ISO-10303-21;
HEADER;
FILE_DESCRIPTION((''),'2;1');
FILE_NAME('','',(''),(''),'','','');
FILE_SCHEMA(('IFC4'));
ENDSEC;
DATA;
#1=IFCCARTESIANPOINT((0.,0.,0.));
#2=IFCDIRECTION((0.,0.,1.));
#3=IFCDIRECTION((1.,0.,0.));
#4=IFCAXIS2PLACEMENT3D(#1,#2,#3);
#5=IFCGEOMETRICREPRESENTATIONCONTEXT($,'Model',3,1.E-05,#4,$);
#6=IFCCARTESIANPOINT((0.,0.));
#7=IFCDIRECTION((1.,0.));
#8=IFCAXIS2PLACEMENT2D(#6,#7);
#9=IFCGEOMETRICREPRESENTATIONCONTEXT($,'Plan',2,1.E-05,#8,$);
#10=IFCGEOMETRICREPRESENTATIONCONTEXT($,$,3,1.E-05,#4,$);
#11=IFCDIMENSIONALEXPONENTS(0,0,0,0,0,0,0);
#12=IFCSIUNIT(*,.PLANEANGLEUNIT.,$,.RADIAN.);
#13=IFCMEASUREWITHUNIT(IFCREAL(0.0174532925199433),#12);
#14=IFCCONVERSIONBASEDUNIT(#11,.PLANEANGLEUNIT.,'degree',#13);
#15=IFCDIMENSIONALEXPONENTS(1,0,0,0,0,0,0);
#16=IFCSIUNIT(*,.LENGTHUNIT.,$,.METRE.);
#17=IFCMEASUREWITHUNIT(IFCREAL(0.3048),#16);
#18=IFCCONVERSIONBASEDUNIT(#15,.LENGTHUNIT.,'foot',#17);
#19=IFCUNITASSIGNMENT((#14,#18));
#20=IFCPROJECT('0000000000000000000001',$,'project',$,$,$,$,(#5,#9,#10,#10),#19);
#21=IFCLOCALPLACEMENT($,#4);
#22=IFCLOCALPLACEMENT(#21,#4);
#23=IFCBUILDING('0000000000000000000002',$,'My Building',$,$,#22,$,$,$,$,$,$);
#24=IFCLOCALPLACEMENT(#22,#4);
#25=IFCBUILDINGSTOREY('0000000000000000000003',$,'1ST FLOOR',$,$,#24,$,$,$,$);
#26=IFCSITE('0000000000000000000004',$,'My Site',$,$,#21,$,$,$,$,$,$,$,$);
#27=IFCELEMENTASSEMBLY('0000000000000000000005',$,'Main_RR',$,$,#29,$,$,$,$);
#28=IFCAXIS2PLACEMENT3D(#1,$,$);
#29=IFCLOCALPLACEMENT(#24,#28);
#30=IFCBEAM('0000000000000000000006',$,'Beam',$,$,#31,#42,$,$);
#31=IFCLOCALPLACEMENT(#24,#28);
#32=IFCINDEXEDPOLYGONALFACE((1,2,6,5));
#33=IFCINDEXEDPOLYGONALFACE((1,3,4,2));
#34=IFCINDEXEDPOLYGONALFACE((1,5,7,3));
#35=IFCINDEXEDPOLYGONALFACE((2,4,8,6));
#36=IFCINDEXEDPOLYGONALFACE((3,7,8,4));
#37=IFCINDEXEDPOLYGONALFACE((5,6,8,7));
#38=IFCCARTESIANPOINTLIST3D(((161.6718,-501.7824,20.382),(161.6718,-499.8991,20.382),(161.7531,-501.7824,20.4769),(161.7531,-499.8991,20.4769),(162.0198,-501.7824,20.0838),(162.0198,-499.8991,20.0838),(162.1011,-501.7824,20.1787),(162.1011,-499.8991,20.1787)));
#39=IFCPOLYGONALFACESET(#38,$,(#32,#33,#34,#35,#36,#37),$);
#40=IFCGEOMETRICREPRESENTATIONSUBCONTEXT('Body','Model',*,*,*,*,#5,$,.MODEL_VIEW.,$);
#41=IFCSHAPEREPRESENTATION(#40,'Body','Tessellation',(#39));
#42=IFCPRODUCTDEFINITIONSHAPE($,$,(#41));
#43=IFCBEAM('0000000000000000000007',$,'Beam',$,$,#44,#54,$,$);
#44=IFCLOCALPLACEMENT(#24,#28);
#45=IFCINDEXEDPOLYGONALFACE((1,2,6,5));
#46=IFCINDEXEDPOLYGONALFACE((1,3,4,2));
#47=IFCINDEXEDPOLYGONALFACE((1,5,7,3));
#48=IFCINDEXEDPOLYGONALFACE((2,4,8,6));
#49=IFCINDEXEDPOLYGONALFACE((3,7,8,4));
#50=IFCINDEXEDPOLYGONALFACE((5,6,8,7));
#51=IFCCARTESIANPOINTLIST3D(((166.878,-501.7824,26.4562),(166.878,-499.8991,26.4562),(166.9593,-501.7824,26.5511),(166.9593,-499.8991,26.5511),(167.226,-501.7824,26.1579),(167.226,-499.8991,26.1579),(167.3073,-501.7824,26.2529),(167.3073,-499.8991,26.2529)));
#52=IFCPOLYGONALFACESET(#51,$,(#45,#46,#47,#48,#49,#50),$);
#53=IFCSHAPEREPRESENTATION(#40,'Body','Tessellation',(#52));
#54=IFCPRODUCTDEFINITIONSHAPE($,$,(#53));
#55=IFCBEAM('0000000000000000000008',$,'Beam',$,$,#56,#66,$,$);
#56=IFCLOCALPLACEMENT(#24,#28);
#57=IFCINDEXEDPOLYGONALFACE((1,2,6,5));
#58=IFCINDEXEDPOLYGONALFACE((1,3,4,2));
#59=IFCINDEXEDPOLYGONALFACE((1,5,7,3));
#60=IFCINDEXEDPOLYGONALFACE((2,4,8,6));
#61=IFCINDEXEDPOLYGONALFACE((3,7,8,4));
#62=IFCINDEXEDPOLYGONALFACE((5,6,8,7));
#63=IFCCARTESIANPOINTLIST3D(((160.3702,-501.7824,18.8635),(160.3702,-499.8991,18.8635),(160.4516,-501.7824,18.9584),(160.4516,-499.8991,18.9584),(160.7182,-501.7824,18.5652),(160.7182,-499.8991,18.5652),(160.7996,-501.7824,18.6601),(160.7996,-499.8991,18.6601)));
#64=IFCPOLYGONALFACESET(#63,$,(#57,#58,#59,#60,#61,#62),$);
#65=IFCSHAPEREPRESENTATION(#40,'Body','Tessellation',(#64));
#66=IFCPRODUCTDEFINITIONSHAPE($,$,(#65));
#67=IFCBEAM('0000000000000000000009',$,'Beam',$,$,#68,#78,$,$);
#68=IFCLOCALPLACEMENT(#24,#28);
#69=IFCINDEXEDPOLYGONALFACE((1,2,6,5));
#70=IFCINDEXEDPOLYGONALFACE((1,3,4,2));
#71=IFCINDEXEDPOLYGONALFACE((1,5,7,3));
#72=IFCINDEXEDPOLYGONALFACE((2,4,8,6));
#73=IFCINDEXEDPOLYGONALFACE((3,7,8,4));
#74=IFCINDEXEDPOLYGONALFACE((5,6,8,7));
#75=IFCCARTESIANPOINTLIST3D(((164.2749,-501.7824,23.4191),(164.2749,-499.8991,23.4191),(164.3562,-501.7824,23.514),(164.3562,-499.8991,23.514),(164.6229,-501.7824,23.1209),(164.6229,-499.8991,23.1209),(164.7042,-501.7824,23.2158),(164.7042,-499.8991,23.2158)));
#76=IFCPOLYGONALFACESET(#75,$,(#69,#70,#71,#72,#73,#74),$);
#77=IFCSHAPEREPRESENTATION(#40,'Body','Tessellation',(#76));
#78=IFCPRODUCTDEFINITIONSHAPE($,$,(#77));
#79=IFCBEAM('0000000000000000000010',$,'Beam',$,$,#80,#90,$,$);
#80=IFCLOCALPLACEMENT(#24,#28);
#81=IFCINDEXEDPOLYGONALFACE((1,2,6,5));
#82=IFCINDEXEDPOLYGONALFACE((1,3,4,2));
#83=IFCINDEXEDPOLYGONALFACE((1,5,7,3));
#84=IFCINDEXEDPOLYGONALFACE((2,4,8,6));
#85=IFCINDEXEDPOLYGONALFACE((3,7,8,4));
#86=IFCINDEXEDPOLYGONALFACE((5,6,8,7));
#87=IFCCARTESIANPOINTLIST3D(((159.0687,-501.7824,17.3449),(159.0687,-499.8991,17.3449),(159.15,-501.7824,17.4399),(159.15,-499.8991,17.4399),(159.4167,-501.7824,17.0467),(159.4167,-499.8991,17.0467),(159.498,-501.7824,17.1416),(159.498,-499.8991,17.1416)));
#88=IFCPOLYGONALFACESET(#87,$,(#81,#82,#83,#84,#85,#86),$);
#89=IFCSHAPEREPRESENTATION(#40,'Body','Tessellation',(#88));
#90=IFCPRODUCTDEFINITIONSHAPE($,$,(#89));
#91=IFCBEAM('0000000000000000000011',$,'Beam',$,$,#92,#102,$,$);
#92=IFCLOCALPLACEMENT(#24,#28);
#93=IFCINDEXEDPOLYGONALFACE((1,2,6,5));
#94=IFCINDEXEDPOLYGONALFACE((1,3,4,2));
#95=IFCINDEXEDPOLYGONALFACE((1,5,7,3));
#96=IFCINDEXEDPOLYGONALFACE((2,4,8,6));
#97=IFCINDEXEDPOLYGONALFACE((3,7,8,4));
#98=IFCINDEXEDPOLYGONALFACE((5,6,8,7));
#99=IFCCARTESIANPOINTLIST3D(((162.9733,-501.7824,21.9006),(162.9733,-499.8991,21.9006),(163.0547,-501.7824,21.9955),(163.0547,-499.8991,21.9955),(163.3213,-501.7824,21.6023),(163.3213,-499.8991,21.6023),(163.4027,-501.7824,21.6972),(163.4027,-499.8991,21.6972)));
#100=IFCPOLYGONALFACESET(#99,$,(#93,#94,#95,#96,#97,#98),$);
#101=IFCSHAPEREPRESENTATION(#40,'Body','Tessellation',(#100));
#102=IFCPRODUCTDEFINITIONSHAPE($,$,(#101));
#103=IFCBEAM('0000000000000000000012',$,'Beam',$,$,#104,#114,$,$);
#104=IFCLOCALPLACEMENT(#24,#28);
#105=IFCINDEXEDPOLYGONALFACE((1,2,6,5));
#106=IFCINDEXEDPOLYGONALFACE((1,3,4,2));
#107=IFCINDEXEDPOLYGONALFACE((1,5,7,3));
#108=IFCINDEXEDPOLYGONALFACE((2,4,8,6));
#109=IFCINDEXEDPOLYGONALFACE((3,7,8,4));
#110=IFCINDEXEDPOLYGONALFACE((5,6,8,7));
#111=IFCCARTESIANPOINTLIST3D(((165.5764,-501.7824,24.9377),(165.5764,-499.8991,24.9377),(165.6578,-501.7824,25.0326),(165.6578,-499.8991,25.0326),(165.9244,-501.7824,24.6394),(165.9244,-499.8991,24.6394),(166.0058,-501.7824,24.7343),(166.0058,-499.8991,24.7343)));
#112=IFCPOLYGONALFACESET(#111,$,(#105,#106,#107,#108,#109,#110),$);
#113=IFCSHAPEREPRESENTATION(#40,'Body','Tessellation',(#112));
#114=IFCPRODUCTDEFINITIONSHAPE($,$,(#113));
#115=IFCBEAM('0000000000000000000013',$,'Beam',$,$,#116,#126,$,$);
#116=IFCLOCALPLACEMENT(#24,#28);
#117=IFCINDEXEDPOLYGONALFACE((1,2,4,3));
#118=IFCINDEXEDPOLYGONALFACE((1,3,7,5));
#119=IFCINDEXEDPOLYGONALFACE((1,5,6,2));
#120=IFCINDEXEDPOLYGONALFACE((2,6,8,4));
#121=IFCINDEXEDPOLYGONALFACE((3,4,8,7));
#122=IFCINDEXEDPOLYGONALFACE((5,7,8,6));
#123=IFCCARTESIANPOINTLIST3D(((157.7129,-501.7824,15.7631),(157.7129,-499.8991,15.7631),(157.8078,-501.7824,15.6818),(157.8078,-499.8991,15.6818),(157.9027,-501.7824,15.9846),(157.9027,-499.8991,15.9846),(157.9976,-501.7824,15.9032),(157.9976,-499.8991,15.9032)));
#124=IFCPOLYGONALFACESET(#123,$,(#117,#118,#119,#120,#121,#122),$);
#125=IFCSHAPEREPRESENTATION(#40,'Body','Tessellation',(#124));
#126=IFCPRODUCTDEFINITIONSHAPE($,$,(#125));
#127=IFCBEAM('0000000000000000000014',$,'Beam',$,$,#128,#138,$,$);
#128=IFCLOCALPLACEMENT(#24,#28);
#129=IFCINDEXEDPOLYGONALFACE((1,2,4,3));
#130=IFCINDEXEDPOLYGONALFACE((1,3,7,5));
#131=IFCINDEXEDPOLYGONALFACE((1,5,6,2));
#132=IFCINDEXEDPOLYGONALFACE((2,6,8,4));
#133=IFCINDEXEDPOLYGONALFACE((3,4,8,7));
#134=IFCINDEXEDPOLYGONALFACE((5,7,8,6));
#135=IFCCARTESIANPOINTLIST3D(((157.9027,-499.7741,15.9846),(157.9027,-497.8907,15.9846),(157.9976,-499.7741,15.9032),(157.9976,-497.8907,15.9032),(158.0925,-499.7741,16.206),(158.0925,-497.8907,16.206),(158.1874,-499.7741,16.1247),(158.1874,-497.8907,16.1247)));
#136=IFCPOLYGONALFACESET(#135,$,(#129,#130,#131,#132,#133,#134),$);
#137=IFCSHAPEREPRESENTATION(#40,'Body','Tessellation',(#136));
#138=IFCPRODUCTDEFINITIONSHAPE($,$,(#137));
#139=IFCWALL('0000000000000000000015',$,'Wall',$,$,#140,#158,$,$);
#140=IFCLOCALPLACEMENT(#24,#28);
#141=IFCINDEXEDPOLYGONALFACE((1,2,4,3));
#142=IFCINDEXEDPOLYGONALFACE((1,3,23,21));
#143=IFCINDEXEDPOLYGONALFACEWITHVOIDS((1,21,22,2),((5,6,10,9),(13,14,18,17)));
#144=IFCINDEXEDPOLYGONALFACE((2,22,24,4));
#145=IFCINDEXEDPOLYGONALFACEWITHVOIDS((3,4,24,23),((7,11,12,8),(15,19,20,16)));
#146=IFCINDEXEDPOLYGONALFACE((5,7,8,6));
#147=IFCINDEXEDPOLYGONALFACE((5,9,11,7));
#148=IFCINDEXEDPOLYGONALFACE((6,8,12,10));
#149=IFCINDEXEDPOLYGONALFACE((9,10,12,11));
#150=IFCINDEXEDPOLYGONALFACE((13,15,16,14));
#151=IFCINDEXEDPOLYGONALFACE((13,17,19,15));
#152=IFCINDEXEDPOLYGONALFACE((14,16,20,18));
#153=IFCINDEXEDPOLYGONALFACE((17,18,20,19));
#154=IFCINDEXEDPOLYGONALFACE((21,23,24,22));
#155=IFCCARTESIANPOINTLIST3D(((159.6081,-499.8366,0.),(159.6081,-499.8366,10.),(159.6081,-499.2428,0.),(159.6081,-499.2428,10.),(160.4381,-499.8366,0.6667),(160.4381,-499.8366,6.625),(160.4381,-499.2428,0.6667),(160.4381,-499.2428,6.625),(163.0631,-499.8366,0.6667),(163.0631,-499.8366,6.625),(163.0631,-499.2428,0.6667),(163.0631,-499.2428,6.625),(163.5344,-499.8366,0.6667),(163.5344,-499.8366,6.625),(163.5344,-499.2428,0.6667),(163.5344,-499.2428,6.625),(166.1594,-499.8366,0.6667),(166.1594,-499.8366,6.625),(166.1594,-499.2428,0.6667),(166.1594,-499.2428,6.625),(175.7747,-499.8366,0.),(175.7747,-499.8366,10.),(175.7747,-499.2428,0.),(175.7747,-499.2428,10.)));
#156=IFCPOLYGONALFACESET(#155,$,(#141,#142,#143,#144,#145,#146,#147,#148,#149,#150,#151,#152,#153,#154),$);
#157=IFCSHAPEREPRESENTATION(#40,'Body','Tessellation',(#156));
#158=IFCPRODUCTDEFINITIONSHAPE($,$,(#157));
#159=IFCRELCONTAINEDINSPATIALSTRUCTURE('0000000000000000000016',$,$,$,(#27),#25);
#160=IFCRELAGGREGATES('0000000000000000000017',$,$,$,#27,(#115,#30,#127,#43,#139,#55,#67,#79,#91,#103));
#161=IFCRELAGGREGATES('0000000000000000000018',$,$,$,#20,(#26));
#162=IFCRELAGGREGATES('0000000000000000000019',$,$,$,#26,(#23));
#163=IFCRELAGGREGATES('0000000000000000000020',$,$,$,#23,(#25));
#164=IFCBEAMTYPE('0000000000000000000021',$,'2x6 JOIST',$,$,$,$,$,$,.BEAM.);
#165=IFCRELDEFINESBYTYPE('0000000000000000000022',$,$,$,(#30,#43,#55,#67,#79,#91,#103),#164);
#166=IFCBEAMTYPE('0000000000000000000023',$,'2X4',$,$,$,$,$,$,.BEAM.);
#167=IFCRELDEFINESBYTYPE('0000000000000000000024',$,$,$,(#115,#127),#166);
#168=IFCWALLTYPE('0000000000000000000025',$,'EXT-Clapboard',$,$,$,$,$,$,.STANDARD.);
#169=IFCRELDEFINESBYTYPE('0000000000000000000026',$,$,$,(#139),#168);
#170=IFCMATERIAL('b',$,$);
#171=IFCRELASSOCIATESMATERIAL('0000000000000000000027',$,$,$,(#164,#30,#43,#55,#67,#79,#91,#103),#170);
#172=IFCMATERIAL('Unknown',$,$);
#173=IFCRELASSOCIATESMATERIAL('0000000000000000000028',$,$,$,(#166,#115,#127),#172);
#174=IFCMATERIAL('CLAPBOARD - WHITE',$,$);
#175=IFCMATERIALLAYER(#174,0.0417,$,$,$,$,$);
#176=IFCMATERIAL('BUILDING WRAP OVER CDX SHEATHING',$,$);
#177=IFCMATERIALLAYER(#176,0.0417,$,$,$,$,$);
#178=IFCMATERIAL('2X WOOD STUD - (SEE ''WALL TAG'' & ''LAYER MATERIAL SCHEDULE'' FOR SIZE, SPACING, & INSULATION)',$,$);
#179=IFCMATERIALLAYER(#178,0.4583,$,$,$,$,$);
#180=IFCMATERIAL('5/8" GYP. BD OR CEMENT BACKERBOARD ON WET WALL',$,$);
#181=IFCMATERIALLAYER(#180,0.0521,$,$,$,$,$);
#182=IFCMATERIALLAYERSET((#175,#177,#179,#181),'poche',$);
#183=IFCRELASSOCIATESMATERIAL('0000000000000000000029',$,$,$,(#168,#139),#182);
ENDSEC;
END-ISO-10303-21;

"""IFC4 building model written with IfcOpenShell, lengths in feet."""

from ifc_helpers import new_model, entity, si_unit, converted_unit, frame, origin_with_axes, origin_2d_with_axis, place, context, subcontext, project, spatial, line, indexed_curve, rectangle, outline, extrude, source, transform, mapped, material, layer, layer_set, layer_usage, material_profile, profile_set, profile_usage, type_object, element, aggregate, save


model = new_model("IFC4")

# Units and contexts
model_context = context("Model", 3, precision=1e-05, world=origin_with_axes())
plan_context = context("Plan", 2, precision=1e-05, world=origin_2d_with_axis())
context_of_model = context(None, 3, precision=1e-05, world=origin_with_axes())
body_context = subcontext(model_context, "Body", "Model", "MODEL_VIEW")
ifc_project = project(units=[converted_unit("PLANEANGLEUNIT", "degree", entity("IfcReal", 0.0174532925199433), si_unit("PLANEANGLEUNIT", "RADIAN"), dimensions=[0, 0, 0, 0, 0, 0, 0]), converted_unit("LENGTHUNIT", "foot", entity("IfcReal", 0.3048), si_unit("LENGTHUNIT", "METRE"), dimensions=[1, 0, 0, 0, 0, 0, 0])], contexts=[model_context, plan_context, context_of_model, context_of_model])

# Site, building, storey
site_placement = place(None, origin_with_axes())
site = spatial("IfcSite", under=ifc_project, at=site_placement, Name="My Site")
building_placement = place(site_placement, origin_with_axes())
building = spatial("IfcBuilding", under=site, at=building_placement, Name="My Building")
storey_placement = place(building_placement, origin_with_axes())
storey = spatial("IfcBuildingStorey", under=building, at=storey_placement, Name="1ST FLOOR")

# Element assembly, beams, wall, openings
assembly_placement = place(storey_placement, origin_with_axes())
assembly = element("IfcElementAssembly", 1, at=assembly_placement, inside=storey, Name="Main_RR")
ifc_material_1 = material(Name="b")
ifc_material_profile_1 = material_profile(ifc_material_1, rectangle(XDim=0.125, YDim=0.4583))
ifc_profile_set_1 = profile_set([ifc_material_profile_1])
beam_type_1 = type_object("IfcBeamType", Name="2x6 JOIST", PredefinedType="BEAM", material=ifc_profile_set_1)
ifc_profile_usage_1 = profile_usage(ifc_profile_set_1, cardinal=8)
beam_1_placement = place(assembly_placement, frame((161.7125, -499.8991, 20.4295), z_axis=(0.0, -1.0, 0.0), x_axis=(0.650774, 0.0, 0.759271)))
beam_1 = element("IfcBeam", 2, at=beam_1_placement, type_object=beam_type_1, material=ifc_profile_usage_1, Name="Beam", context=body_context, shape_type="SweptSolid", body=[
    extrude(rectangle(XDim=0.125, YDim=0.4583), frame((0.0, -0.2291, 0.0)), (0.0, 0.0, 1.0), 1.8833),
])
ifc_profile_usage_2 = profile_usage(ifc_profile_set_1, cardinal=8)
beam_2_placement = place(assembly_placement, frame((166.9187, -499.8991, 26.5037), z_axis=(0.0, -1.0, 0.0), x_axis=(0.650774, 0.0, 0.759271)))
beam_2 = element("IfcBeam", 3, at=beam_2_placement, type_object=beam_type_1, material=ifc_profile_usage_2, Name="Beam", context=body_context, shape_type="SweptSolid", body=[
    extrude(rectangle(XDim=0.125, YDim=0.4583), frame((0.0, -0.2291, 0.0)), (0.0, 0.0, 1.0), 1.8833),
])
ifc_profile_usage_3 = profile_usage(ifc_profile_set_1, cardinal=8)
beam_3_placement = place(assembly_placement, frame((160.4109, -499.8991, 18.9109), z_axis=(0.0, -1.0, 0.0), x_axis=(0.650774, 0.0, 0.759271)))
beam_3 = element("IfcBeam", 4, at=beam_3_placement, type_object=beam_type_1, material=ifc_profile_usage_3, Name="Beam", context=body_context, shape_type="SweptSolid", body=[
    extrude(rectangle(XDim=0.125, YDim=0.4583), frame((0.0, -0.2291, 0.0)), (0.0, 0.0, 1.0), 1.8833),
])
ifc_profile_usage_4 = profile_usage(ifc_profile_set_1, cardinal=8)
beam_4_placement = place(assembly_placement, frame((164.3156, -499.8991, 23.4666), z_axis=(0.0, -1.0, 0.0), x_axis=(0.650774, 0.0, 0.759271)))
beam_4 = element("IfcBeam", 5, at=beam_4_placement, type_object=beam_type_1, material=ifc_profile_usage_4, Name="Beam", context=body_context, shape_type="SweptSolid", body=[
    extrude(rectangle(XDim=0.125, YDim=0.4583), frame((0.0, -0.2291, 0.0)), (0.0, 0.0, 1.0), 1.8833),
])
ifc_profile_usage_5 = profile_usage(ifc_profile_set_1, cardinal=8)
beam_5_placement = place(assembly_placement, frame((159.1094, -499.8991, 17.3924), z_axis=(0.0, -1.0, 0.0), x_axis=(0.650774, 0.0, 0.759271)))
beam_5 = element("IfcBeam", 6, at=beam_5_placement, type_object=beam_type_1, material=ifc_profile_usage_5, Name="Beam", context=body_context, shape_type="SweptSolid", body=[
    extrude(rectangle(XDim=0.125, YDim=0.4583), frame((0.0, -0.2291, 0.0)), (0.0, 0.0, 1.0), 1.8833),
])
ifc_profile_usage_6 = profile_usage(ifc_profile_set_1, cardinal=8)
beam_6_placement = place(assembly_placement, frame((163.014, -499.8991, 21.948), z_axis=(0.0, -1.0, 0.0), x_axis=(0.650774, 0.0, 0.759271)))
beam_6 = element("IfcBeam", 7, at=beam_6_placement, type_object=beam_type_1, material=ifc_profile_usage_6, Name="Beam", context=body_context, shape_type="SweptSolid", body=[
    extrude(rectangle(XDim=0.125, YDim=0.4583), frame((0.0, -0.2291, 0.0)), (0.0, 0.0, 1.0), 1.8833),
])
ifc_profile_usage_7 = profile_usage(ifc_profile_set_1, cardinal=8)
beam_7_placement = place(assembly_placement, frame((165.6171, -499.8991, 24.9851), z_axis=(0.0, -1.0, 0.0), x_axis=(0.650774, 0.0, 0.759271)))
beam_7 = element("IfcBeam", 8, at=beam_7_placement, type_object=beam_type_1, material=ifc_profile_usage_7, Name="Beam", context=body_context, shape_type="SweptSolid", body=[
    extrude(rectangle(XDim=0.125, YDim=0.4583), frame((0.0, -0.2291, 0.0)), (0.0, 0.0, 1.0), 1.8833),
])
ifc_material_2 = material(Name="Unknown")
ifc_material_profile_2 = material_profile(ifc_material_2, rectangle(XDim=0.125, YDim=0.2917))
ifc_profile_set_2 = profile_set([ifc_material_profile_2])
ifc_profile_usage_8 = profile_usage(ifc_profile_set_2, cardinal=5)
beam_type_2 = type_object("IfcBeamType", Name="2X4", PredefinedType="BEAM", material=ifc_profile_set_2)
beam_8_placement = place(assembly_placement, frame((157.8553, -499.8991, 15.8332), z_axis=(0.0, -1.0, 0.0), x_axis=(-0.759271, 0.0, 0.650774)))
beam_8 = element("IfcBeam", 9, at=beam_8_placement, type_object=beam_type_2, material=ifc_profile_usage_8, Name="Beam", context=body_context, shape_type="SweptSolid", body=[
    extrude(rectangle(XDim=0.125, YDim=0.2917), origin_with_axes(), (0.0, 0.0, 1.0), 1.8833),
])
ifc_profile_usage_9 = profile_usage(ifc_profile_set_2, cardinal=5)
beam_9_placement = place(assembly_placement, frame((158.0451, -497.8907, 16.0546), z_axis=(0.0, -1.0, 0.0), x_axis=(-0.759271, 0.0, 0.650774)))
beam_9 = element("IfcBeam", 10, at=beam_9_placement, type_object=beam_type_2, material=ifc_profile_usage_9, Name="Beam", context=body_context, shape_type="SweptSolid", body=[
    extrude(rectangle(XDim=0.125, YDim=0.2917), origin_with_axes(), (0.0, 0.0, 1.0), 1.8833),
])
ifc_material_3 = material(Name="CLAPBOARD - WHITE")
ifc_layer_1 = layer(ifc_material_3, 0.0417)
ifc_material_4 = material(Name="BUILDING WRAP OVER CDX SHEATHING")
ifc_layer_2 = layer(ifc_material_4, 0.0417)
ifc_material_5 = material(Name="2X WOOD STUD - (SEE 'WALL TAG' & 'LAYER MATERIAL SCHEDULE' FOR SIZE, SPACING, & INSULATION)")
ifc_layer_3 = layer(ifc_material_5, 0.4583)
ifc_material_6 = material(Name="5/8\" GYP. BD OR CEMENT BACKERBOARD ON WET WALL")
ifc_layer_4 = layer(ifc_material_6, 0.0521)
ifc_layer_set_1 = layer_set([ifc_layer_1, ifc_layer_2, ifc_layer_3, ifc_layer_4], Name="poche")
wall_type_1 = type_object("IfcWallType", Name="EXT-Clapboard", PredefinedType="STANDARD", material=ifc_layer_set_1)
shared_shape_1 = source(origin_with_axes(), body_context, "Body", "SweptSolid", [
    extrude(outline(indexed_curve([(0.0, 0.0), (2.625, 0.0), (2.625, 5.9583), (0.0, 5.9583)], segments=[line(1, 2, 3, 4, 1)])), frame((0.0, -1.9685, 0.0), z_axis=(0.0, -1.0, 0.0), x_axis=(1.0, 0.0, 0.0)), (0.0, 0.0, -1.0), 3.937),
])
ifc_layer_usage_1 = layer_usage(ifc_layer_set_1, "AXIS2", "POSITIVE", 0.0)
wall_1_placement = place(assembly_placement, frame((159.6081, -499.8366, 0.0), z_axis=(0.0, 0.0, 1.0), x_axis=(1.0, 0.0, 0.0)))
wall_1 = element("IfcWall", 11, at=wall_1_placement, type_object=wall_type_1, material=ifc_layer_usage_1, Name="Wall", context=body_context, shape_type="SweptSolid", body=[
    extrude(outline(indexed_curve([(0.0, 0.0), (0.0, 0.5938), (16.1666, 0.5938), (16.1666, 0.0), (0.0, 0.0)], self_intersect=False)), origin_with_axes(), (0.0, 0.0, 1.0), 10.0),
])
opening_1_placement = place(wall_1_placement, frame((0.83, 0.0, 0.6667), z_axis=(0.0, 0.0, 1.0), x_axis=(1.0, 0.0, 0.0)))
element("IfcOpeningElement", 12, at=opening_1_placement, cuts=wall_1, PredefinedType="OPENING", context=body_context, shape_type="MappedRepresentation", body=[
    mapped(shared_shape_1, transform((0.0, 0.0, 0.0), x_axis=(1.0, 0.0, 0.0), y_axis=(0.0, 1.0, 0.0), z_axis=(0.0, 0.0, 1.0), scale=1.0)),
])
opening_2_placement = place(wall_1_placement, frame((3.9263, 0.0, 0.6667), z_axis=(0.0, 0.0, 1.0), x_axis=(1.0, 0.0, 0.0)))
element("IfcOpeningElement", 13, at=opening_2_placement, cuts=wall_1, PredefinedType="OPENING", context=body_context, shape_type="MappedRepresentation", body=[
    mapped(shared_shape_1, transform((0.0, 0.0, 0.0), x_axis=(1.0, 0.0, 0.0), y_axis=(0.0, 1.0, 0.0), z_axis=(0.0, 0.0, 1.0), scale=1.0)),
])
aggregate(assembly, [beam_8, beam_1, beam_9, beam_2, wall_1, beam_3, beam_4, beam_5, beam_6, beam_7])

save(model, "model.ifc")
